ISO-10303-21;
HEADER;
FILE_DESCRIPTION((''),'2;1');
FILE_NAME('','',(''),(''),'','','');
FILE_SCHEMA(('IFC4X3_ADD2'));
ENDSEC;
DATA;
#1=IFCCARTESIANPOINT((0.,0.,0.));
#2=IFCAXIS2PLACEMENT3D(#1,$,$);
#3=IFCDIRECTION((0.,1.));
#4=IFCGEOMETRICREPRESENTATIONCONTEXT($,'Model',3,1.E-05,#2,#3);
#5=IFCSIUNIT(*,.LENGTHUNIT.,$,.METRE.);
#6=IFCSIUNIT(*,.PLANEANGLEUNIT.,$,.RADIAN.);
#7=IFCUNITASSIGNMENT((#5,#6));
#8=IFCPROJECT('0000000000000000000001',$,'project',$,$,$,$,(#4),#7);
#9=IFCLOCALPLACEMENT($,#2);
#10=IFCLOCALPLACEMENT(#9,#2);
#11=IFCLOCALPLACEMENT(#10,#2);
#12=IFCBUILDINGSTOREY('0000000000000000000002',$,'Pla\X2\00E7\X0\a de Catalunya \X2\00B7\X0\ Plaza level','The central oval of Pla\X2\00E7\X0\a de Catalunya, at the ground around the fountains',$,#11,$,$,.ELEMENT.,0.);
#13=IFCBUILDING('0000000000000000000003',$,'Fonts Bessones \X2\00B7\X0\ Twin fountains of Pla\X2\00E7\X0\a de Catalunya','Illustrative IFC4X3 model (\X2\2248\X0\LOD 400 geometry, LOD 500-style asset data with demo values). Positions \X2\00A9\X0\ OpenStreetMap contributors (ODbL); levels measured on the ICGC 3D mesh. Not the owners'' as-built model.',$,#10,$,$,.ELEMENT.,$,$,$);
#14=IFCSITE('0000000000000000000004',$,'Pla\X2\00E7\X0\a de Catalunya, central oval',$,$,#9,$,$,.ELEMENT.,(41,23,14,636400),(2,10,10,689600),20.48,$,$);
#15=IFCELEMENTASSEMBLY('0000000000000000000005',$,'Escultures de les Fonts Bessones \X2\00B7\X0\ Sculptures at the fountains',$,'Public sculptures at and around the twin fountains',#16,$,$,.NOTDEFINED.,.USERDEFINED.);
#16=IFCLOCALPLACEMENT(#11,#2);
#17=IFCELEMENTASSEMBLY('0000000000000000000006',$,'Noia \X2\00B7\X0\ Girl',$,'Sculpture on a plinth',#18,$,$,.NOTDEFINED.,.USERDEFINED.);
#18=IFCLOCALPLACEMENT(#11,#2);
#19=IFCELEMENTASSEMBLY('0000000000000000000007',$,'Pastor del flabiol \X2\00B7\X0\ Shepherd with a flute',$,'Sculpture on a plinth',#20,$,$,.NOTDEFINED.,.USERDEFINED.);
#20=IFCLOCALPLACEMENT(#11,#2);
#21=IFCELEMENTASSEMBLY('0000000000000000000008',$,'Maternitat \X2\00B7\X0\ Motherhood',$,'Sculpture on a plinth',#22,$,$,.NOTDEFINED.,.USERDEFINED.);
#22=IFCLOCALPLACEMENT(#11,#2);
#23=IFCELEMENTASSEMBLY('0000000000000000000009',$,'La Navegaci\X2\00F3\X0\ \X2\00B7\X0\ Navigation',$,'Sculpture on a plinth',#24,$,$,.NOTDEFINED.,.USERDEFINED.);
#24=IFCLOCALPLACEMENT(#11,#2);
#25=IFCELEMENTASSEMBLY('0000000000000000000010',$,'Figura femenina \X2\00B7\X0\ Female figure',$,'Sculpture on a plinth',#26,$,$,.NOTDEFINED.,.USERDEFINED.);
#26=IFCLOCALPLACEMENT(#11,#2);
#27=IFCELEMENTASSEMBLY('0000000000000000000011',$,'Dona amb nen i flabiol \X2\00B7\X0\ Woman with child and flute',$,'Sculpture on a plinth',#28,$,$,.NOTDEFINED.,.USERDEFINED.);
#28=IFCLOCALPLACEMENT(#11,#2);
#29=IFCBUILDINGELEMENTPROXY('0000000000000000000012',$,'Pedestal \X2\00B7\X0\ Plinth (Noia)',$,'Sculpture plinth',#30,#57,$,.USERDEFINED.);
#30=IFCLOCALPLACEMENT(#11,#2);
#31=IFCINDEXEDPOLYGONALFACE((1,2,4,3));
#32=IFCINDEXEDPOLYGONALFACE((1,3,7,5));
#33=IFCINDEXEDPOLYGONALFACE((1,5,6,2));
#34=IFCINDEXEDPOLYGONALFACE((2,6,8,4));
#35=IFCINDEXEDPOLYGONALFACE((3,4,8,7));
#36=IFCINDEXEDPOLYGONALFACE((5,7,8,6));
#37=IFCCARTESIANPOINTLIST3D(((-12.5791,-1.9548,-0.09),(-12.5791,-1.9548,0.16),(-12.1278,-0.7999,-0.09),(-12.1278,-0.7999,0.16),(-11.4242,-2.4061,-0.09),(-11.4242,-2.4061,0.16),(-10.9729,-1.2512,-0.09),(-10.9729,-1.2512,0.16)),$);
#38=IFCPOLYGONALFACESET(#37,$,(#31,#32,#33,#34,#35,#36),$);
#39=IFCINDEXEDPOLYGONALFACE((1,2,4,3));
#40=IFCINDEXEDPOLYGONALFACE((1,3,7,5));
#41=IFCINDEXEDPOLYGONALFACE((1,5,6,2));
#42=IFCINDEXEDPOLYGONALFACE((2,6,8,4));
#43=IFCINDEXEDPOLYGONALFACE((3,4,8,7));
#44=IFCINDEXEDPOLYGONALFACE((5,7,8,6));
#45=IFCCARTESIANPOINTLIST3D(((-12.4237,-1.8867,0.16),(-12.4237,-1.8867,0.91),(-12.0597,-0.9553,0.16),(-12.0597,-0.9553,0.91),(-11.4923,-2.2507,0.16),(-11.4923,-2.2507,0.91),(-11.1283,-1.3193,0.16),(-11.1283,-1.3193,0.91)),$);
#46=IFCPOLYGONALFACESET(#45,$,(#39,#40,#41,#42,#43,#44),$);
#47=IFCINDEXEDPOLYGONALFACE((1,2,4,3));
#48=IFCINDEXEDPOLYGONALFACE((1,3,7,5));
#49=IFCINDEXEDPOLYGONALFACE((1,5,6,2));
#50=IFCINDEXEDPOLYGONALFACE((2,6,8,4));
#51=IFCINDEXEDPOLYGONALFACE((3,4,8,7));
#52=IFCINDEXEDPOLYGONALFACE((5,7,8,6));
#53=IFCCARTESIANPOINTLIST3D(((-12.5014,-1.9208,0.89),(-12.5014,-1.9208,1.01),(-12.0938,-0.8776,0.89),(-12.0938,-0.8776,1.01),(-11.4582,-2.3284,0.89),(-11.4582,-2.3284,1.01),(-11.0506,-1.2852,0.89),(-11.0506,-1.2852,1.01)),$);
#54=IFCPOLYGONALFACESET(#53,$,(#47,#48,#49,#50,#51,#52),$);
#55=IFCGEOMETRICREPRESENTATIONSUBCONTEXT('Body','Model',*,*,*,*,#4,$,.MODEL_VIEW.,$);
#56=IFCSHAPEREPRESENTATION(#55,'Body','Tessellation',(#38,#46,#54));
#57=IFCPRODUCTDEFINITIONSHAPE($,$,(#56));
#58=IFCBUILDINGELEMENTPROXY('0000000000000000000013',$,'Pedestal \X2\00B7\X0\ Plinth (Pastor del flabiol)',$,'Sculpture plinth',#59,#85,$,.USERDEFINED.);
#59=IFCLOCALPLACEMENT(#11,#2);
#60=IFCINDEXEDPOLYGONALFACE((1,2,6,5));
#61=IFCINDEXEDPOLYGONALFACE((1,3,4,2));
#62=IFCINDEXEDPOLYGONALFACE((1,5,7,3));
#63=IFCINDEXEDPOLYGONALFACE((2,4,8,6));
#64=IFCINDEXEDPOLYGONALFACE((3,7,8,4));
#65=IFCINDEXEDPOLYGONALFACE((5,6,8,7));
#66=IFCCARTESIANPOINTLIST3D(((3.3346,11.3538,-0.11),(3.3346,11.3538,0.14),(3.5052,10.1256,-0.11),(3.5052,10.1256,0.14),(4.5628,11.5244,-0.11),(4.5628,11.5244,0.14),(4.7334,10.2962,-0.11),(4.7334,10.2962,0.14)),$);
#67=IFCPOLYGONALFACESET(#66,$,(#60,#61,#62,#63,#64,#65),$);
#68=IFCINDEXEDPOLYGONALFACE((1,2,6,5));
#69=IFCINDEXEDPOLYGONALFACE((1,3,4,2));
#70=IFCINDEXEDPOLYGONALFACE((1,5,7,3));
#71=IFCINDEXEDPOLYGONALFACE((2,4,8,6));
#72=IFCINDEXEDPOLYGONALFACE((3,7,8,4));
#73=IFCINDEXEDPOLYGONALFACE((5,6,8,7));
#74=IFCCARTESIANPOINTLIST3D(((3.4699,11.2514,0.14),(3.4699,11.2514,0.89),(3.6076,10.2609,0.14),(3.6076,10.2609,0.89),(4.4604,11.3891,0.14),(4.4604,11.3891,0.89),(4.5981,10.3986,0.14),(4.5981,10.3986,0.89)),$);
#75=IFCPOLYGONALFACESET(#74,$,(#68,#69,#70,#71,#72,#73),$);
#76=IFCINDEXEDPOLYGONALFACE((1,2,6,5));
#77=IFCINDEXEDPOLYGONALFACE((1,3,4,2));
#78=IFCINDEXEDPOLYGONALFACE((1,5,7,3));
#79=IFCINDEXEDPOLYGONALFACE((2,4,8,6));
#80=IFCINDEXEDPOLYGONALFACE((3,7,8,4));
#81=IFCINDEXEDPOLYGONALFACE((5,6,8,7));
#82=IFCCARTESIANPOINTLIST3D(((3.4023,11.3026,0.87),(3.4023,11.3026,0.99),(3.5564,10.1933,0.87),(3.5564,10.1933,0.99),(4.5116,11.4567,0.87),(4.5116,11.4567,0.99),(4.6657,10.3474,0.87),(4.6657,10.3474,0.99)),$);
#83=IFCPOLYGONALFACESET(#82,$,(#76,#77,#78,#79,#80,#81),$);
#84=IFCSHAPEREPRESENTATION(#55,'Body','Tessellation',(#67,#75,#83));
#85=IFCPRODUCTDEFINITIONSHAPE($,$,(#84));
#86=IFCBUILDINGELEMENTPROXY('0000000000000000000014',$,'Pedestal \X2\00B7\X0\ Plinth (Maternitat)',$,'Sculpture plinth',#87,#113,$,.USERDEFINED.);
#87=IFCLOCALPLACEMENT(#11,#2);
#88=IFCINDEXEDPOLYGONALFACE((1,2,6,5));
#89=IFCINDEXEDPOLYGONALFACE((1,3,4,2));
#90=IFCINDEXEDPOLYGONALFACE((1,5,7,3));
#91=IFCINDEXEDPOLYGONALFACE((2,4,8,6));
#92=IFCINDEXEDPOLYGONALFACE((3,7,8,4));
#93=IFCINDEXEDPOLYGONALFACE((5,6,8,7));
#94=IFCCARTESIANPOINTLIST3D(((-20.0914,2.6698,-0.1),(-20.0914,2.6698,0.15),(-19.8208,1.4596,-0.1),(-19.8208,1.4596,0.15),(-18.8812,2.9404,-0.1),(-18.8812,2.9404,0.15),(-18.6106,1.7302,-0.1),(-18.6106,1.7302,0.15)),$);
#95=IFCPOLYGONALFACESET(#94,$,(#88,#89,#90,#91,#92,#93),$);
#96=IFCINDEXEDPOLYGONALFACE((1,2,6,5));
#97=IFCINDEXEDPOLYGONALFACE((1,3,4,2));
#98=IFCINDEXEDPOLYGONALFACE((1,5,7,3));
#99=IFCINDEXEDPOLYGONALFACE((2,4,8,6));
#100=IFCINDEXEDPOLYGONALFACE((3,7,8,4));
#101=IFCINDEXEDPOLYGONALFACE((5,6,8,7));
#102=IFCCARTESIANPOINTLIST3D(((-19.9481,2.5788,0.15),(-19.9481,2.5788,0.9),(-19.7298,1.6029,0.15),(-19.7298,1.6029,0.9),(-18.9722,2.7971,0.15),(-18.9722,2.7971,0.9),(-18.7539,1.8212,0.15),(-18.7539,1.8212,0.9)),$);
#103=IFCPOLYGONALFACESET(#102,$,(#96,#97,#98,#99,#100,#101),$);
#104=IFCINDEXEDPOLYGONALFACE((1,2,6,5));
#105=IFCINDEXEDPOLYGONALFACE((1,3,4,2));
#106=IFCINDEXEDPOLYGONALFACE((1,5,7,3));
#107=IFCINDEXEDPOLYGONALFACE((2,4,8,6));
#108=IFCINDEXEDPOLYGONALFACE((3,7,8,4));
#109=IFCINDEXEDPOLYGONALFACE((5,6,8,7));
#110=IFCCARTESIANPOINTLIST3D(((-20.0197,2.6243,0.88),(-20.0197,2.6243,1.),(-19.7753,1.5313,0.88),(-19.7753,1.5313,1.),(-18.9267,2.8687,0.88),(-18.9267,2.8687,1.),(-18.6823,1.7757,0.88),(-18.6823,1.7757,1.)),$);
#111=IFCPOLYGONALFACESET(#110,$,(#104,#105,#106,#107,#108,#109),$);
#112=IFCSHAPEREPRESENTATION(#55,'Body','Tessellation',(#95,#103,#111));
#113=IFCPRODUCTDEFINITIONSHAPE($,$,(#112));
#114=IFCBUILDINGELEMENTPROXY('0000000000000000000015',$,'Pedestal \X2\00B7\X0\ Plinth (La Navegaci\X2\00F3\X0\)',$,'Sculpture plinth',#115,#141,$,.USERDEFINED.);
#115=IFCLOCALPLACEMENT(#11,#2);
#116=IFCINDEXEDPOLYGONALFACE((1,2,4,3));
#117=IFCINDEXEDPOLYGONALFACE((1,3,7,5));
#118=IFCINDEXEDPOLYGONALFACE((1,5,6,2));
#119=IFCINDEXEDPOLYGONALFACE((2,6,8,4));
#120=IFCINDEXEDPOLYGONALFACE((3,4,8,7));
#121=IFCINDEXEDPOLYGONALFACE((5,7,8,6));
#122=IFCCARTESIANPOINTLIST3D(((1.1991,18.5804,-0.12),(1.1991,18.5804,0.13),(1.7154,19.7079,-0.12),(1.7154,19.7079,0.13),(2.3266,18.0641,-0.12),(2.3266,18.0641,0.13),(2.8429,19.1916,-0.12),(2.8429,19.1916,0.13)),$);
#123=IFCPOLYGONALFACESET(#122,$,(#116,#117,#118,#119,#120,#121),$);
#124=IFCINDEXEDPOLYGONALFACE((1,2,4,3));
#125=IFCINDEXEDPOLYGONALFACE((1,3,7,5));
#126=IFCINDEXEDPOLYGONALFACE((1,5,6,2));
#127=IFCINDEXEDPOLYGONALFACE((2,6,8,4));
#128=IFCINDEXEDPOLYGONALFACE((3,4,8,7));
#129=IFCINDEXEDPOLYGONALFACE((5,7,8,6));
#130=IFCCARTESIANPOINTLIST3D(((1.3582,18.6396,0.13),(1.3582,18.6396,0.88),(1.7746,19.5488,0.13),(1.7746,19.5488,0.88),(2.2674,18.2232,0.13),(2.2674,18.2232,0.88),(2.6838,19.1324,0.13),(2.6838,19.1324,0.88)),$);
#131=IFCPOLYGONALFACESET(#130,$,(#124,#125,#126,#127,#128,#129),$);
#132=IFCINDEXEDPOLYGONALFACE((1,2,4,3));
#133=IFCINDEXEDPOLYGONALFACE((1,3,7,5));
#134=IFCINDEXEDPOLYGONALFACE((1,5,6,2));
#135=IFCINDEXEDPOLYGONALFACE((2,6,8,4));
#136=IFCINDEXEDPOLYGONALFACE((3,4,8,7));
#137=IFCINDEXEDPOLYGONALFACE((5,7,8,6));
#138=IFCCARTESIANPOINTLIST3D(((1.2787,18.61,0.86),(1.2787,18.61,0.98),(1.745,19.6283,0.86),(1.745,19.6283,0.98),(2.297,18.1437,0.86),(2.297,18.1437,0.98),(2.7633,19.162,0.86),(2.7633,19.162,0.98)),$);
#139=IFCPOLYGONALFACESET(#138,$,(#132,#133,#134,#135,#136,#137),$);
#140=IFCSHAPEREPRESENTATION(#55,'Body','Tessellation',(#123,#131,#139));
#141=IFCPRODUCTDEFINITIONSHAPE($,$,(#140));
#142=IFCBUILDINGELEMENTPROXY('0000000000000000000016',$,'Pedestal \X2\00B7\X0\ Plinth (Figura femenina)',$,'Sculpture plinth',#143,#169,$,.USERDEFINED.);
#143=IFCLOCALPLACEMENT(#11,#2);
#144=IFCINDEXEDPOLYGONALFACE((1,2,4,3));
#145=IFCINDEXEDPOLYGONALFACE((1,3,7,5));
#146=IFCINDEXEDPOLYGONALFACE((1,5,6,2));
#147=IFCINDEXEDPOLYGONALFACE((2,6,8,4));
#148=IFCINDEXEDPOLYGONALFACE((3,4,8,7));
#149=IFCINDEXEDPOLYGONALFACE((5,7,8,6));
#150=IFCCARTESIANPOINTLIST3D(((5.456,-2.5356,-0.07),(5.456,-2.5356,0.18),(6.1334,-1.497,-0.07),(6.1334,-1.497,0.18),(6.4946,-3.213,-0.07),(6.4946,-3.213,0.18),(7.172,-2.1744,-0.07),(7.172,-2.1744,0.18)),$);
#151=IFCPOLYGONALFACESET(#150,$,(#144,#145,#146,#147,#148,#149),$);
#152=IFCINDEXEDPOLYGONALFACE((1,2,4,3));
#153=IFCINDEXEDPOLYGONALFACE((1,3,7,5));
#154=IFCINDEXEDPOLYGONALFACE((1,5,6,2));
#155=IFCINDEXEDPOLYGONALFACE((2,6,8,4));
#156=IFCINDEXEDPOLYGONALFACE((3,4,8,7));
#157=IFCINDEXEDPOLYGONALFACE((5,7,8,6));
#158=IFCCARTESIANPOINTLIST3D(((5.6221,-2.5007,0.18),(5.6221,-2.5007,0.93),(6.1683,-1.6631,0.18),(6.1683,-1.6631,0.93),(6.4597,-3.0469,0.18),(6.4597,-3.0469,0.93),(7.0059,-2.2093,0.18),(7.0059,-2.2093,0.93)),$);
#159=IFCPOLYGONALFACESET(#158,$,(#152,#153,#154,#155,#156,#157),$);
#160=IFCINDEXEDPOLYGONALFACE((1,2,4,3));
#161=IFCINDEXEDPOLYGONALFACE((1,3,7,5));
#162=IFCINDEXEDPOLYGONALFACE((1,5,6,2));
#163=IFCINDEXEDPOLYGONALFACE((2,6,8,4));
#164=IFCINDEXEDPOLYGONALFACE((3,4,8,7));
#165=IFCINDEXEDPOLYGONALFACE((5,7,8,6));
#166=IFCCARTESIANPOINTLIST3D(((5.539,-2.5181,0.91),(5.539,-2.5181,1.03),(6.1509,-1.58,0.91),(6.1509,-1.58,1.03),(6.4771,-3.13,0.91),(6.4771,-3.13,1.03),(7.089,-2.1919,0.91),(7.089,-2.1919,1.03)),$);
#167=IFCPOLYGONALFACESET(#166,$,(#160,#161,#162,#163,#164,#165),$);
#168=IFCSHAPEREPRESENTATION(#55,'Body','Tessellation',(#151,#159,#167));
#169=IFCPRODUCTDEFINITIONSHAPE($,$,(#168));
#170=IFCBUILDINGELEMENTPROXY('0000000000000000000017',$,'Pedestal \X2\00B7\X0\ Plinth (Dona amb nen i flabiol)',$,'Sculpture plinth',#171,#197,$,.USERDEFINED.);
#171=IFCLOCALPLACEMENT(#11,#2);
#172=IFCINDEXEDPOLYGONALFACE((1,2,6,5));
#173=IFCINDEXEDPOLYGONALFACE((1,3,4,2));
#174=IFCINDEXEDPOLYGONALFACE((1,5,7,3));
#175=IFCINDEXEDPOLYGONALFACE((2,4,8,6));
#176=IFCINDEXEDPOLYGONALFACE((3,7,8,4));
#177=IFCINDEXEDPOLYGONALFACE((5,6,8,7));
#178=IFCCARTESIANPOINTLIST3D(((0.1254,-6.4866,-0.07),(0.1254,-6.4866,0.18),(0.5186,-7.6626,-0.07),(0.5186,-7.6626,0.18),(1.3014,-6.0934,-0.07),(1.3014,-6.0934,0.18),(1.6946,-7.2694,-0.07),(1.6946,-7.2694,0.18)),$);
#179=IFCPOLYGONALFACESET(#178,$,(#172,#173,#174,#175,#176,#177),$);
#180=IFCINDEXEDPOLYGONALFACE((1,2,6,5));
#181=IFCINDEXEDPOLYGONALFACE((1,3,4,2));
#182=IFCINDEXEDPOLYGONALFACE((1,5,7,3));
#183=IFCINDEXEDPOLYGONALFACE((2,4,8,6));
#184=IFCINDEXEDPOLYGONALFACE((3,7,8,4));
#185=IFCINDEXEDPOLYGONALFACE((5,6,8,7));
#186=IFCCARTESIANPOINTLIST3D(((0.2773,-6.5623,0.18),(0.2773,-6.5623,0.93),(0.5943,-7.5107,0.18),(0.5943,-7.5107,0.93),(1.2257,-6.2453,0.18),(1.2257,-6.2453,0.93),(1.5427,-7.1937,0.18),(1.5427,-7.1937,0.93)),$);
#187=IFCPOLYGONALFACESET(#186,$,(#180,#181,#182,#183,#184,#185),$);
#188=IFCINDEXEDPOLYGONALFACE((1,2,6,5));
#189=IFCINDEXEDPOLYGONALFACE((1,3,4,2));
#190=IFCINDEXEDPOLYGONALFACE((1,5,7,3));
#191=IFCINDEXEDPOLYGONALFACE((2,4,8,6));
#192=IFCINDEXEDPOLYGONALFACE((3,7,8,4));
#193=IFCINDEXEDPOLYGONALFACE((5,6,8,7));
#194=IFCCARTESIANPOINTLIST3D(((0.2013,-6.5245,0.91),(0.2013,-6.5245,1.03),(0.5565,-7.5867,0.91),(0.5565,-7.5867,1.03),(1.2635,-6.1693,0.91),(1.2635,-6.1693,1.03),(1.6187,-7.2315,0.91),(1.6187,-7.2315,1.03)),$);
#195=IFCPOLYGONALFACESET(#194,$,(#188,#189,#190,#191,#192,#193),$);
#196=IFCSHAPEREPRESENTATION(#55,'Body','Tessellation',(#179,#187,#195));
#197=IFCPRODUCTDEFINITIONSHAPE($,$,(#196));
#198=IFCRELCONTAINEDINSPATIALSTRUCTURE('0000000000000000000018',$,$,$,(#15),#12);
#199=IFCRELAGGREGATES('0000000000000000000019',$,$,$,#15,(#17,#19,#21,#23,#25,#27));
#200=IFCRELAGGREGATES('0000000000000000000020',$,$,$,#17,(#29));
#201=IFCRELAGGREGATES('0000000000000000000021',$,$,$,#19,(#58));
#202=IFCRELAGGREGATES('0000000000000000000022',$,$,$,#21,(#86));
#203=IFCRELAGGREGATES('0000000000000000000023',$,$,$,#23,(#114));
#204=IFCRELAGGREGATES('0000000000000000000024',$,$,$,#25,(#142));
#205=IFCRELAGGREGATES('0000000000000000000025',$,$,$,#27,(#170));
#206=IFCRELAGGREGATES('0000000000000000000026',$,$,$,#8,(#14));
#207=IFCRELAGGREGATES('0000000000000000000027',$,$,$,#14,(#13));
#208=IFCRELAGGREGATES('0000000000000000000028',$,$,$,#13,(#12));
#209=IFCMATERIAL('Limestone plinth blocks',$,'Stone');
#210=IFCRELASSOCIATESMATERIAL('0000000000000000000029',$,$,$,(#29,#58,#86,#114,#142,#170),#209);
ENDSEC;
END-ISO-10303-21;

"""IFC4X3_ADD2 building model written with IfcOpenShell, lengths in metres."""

from ifc_helpers import new_model, si_unit, direction, frame, frame_2d, origin, place, context, subcontext, project, spatial, rectangle, extrude, material, element, aggregate, save


model = new_model("IFC4X3_ADD2")

# Units and contexts
model_context = context("Model", 3, precision=1e-05, world=origin(), true_north=direction((0.0, 1.0)))
body_context = subcontext(model_context, "Body", "Model", "MODEL_VIEW")
ifc_project = project(units=[si_unit("LENGTHUNIT", "METRE"), si_unit("PLANEANGLEUNIT", "RADIAN")], contexts=[model_context])

# Site, building, storey
site_placement = place(None, origin())
site = spatial("IfcSite", under=ifc_project, at=site_placement, Name="Plaça de Catalunya, central oval", CompositionType="ELEMENT", RefLatitude=(41, 23, 14, 636400), RefLongitude=(2, 10, 10, 689600), RefElevation=20.48)
building_placement = place(site_placement, origin())
building = spatial("IfcBuilding", under=site, at=building_placement, Name="Fonts Bessones · Twin fountains of Plaça de Catalunya", Description="Illustrative IFC4X3 model (≈LOD 400 geometry, LOD 500-style asset data with demo values). Positions © OpenStreetMap contributors (ODbL); levels measured on the ICGC 3D mesh. Not the owners' as-built model.", CompositionType="ELEMENT")
storey_placement = place(building_placement, origin())
storey = spatial("IfcBuildingStorey", under=building, at=storey_placement, Name="Plaça de Catalunya · Plaza level", Description="The central oval of Plaça de Catalunya, at the ground around the fountains", CompositionType="ELEMENT", Elevation=0.0)

# Element assemblies
assembly_1_placement = place(building_placement, origin())
assembly_1 = element("IfcElementAssembly", 1, at=assembly_1_placement, inside=storey, Name="Escultures de les Fonts Bessones · Sculptures at the fountains", ObjectType="Public sculptures at and around the twin fountains", AssemblyPlace="NOTDEFINED", PredefinedType="USERDEFINED")
assembly_2_placement = place(building_placement, origin())
assembly_2 = element("IfcElementAssembly", 2, at=assembly_2_placement, Name="Noia · Girl", ObjectType="Sculpture on a plinth", AssemblyPlace="NOTDEFINED", PredefinedType="USERDEFINED")
assembly_3_placement = place(building_placement, origin())
assembly_3 = element("IfcElementAssembly", 3, at=assembly_3_placement, Name="Pastor del flabiol · Shepherd with a flute", ObjectType="Sculpture on a plinth", AssemblyPlace="NOTDEFINED", PredefinedType="USERDEFINED")
assembly_4_placement = place(building_placement, origin())
assembly_4 = element("IfcElementAssembly", 4, at=assembly_4_placement, Name="Maternitat · Motherhood", ObjectType="Sculpture on a plinth", AssemblyPlace="NOTDEFINED", PredefinedType="USERDEFINED")
assembly_5_placement = place(building_placement, origin())
assembly_5 = element("IfcElementAssembly", 5, at=assembly_5_placement, Name="La Navegació · Navigation", ObjectType="Sculpture on a plinth", AssemblyPlace="NOTDEFINED", PredefinedType="USERDEFINED")
assembly_6_placement = place(building_placement, origin())
assembly_6 = element("IfcElementAssembly", 6, at=assembly_6_placement, Name="Figura femenina · Female figure", ObjectType="Sculpture on a plinth", AssemblyPlace="NOTDEFINED", PredefinedType="USERDEFINED")
assembly_7_placement = place(building_placement, origin())
assembly_7 = element("IfcElementAssembly", 7, at=assembly_7_placement, Name="Dona amb nen i flabiol · Woman with child and flute", ObjectType="Sculpture on a plinth", AssemblyPlace="NOTDEFINED", PredefinedType="USERDEFINED")

# Shared definitions
ifc_material_1 = material(Name="Limestone plinth blocks", Category="Stone")

aggregate(assembly_1, [assembly_2, assembly_3, assembly_4, assembly_5, assembly_6, assembly_7])

# Building element proxies
proxy_1_placement = place(building_placement, origin())
proxy_1 = element("IfcBuildingElementProxy", 8, at=proxy_1_placement, material=ifc_material_1, Name="Pedestal · Plinth (Noia)", ObjectType="Sculpture plinth", PredefinedType="USERDEFINED", context=body_context, shape_type="SweptSolid", body=[
    extrude(rectangle(XDim=1.24, YDim=1.24, at=frame_2d((0.0, 0.0), x_axis=(0.363941, 0.931422))), frame((-11.776, -1.603, -0.09)), (0.0, 0.0, 1.0), 0.25),
    extrude(rectangle(XDim=1.0, YDim=1.0, at=frame_2d((0.0, 0.0), x_axis=(0.363941, 0.931422))), frame((-11.776, -1.603, 0.16)), (0.0, 0.0, 1.0), 0.75),
    extrude(rectangle(XDim=1.12, YDim=1.12, at=frame_2d((0.0, 0.0), x_axis=(0.363941, 0.931422))), frame((-11.776, -1.603, 0.89)), (0.0, 0.0, 1.0), 0.12),
])
aggregate(assembly_2, [proxy_1])
proxy_2_placement = place(building_placement, origin())
proxy_2 = element("IfcBuildingElementProxy", 9, at=proxy_2_placement, material=ifc_material_1, Name="Pedestal · Plinth (Pastor del flabiol)", ObjectType="Sculpture plinth", PredefinedType="USERDEFINED", context=body_context, shape_type="SweptSolid", body=[
    extrude(rectangle(XDim=1.24, YDim=1.24, at=frame_2d((0.0, 0.0), x_axis=(-0.990482, -0.137641))), frame((4.034, 10.825, -0.11)), (0.0, 0.0, 1.0), 0.25),
    extrude(rectangle(XDim=1.0, YDim=1.0, at=frame_2d((0.0, 0.0), x_axis=(-0.990482, -0.137641))), frame((4.034, 10.825, 0.14)), (0.0, 0.0, 1.0), 0.75),
    extrude(rectangle(XDim=1.12, YDim=1.12, at=frame_2d((0.0, 0.0), x_axis=(-0.990482, -0.137641))), frame((4.034, 10.825, 0.87)), (0.0, 0.0, 1.0), 0.12),
])
aggregate(assembly_3, [proxy_2])
proxy_3_placement = place(building_placement, origin())
proxy_3 = element("IfcBuildingElementProxy", 10, at=proxy_3_placement, material=ifc_material_1, Name="Pedestal · Plinth (Maternitat)", ObjectType="Sculpture plinth", PredefinedType="USERDEFINED", context=body_context, shape_type="SweptSolid", body=[
    extrude(rectangle(XDim=1.24, YDim=1.24, at=frame_2d((0.0, 0.0), x_axis=(-0.218219, 0.9759))), frame((-19.351, 2.2, -0.1)), (0.0, 0.0, 1.0), 0.25),
    extrude(rectangle(XDim=1.0, YDim=1.0, at=frame_2d((0.0, 0.0), x_axis=(-0.218219, 0.9759))), frame((-19.351, 2.2, 0.15)), (0.0, 0.0, 1.0), 0.75),
    extrude(rectangle(XDim=1.12, YDim=1.12, at=frame_2d((0.0, 0.0), x_axis=(-0.218219, 0.9759))), frame((-19.351, 2.2, 0.88)), (0.0, 0.0, 1.0), 0.12),
])
aggregate(assembly_4, [proxy_3])
proxy_4_placement = place(building_placement, origin())
proxy_4 = element("IfcBuildingElementProxy", 11, at=proxy_4_placement, material=ifc_material_1, Name="Pedestal · Plinth (La Navegació)", ObjectType="Sculpture plinth", PredefinedType="USERDEFINED", context=body_context, shape_type="SweptSolid", body=[
    extrude(rectangle(XDim=1.24, YDim=1.24, at=frame_2d((0.0, 0.0), x_axis=(-0.909195, 0.41637))), frame((2.021, 18.886, -0.12)), (0.0, 0.0, 1.0), 0.25),
    extrude(rectangle(XDim=1.0, YDim=1.0, at=frame_2d((0.0, 0.0), x_axis=(-0.909195, 0.41637))), frame((2.021, 18.886, 0.13)), (0.0, 0.0, 1.0), 0.75),
    extrude(rectangle(XDim=1.12, YDim=1.12, at=frame_2d((0.0, 0.0), x_axis=(-0.909195, 0.41637))), frame((2.021, 18.886, 0.86)), (0.0, 0.0, 1.0), 0.12),
])
aggregate(assembly_5, [proxy_4])
proxy_5_placement = place(building_placement, origin())
proxy_5 = element("IfcBuildingElementProxy", 12, at=proxy_5_placement, material=ifc_material_1, Name="Pedestal · Plinth (Figura femenina)", ObjectType="Sculpture plinth", PredefinedType="USERDEFINED", context=body_context, shape_type="SweptSolid", body=[
    extrude(rectangle(XDim=1.24, YDim=1.24, at=frame_2d((0.0, 0.0), x_axis=(-0.546285, -0.837599))), frame((6.314, -2.355, -0.07)), (0.0, 0.0, 1.0), 0.25),
    extrude(rectangle(XDim=1.0, YDim=1.0, at=frame_2d((0.0, 0.0), x_axis=(-0.546285, -0.837599))), frame((6.314, -2.355, 0.18)), (0.0, 0.0, 1.0), 0.75),
    extrude(rectangle(XDim=1.12, YDim=1.12, at=frame_2d((0.0, 0.0), x_axis=(-0.546285, -0.837599))), frame((6.314, -2.355, 0.91)), (0.0, 0.0, 1.0), 0.12),
])
aggregate(assembly_6, [proxy_5])
proxy_6_placement = place(building_placement, origin())
proxy_6 = element("IfcBuildingElementProxy", 13, at=proxy_6_placement, material=ifc_material_1, Name="Pedestal · Plinth (Dona amb nen i flabiol)", ObjectType="Sculpture plinth", PredefinedType="USERDEFINED", context=body_context, shape_type="SweptSolid", body=[
    extrude(rectangle(XDim=1.24, YDim=1.24, at=frame_2d((0.0, 0.0), x_axis=(0.948403, 0.317066))), frame((0.91, -6.878, -0.07)), (0.0, 0.0, 1.0), 0.25),
    extrude(rectangle(XDim=1.0, YDim=1.0, at=frame_2d((0.0, 0.0), x_axis=(0.948403, 0.317066))), frame((0.91, -6.878, 0.18)), (0.0, 0.0, 1.0), 0.75),
    extrude(rectangle(XDim=1.12, YDim=1.12, at=frame_2d((0.0, 0.0), x_axis=(0.948403, 0.317066))), frame((0.91, -6.878, 0.91)), (0.0, 0.0, 1.0), 0.12),
])
aggregate(assembly_7, [proxy_6])

save(model, "model.ifc")
